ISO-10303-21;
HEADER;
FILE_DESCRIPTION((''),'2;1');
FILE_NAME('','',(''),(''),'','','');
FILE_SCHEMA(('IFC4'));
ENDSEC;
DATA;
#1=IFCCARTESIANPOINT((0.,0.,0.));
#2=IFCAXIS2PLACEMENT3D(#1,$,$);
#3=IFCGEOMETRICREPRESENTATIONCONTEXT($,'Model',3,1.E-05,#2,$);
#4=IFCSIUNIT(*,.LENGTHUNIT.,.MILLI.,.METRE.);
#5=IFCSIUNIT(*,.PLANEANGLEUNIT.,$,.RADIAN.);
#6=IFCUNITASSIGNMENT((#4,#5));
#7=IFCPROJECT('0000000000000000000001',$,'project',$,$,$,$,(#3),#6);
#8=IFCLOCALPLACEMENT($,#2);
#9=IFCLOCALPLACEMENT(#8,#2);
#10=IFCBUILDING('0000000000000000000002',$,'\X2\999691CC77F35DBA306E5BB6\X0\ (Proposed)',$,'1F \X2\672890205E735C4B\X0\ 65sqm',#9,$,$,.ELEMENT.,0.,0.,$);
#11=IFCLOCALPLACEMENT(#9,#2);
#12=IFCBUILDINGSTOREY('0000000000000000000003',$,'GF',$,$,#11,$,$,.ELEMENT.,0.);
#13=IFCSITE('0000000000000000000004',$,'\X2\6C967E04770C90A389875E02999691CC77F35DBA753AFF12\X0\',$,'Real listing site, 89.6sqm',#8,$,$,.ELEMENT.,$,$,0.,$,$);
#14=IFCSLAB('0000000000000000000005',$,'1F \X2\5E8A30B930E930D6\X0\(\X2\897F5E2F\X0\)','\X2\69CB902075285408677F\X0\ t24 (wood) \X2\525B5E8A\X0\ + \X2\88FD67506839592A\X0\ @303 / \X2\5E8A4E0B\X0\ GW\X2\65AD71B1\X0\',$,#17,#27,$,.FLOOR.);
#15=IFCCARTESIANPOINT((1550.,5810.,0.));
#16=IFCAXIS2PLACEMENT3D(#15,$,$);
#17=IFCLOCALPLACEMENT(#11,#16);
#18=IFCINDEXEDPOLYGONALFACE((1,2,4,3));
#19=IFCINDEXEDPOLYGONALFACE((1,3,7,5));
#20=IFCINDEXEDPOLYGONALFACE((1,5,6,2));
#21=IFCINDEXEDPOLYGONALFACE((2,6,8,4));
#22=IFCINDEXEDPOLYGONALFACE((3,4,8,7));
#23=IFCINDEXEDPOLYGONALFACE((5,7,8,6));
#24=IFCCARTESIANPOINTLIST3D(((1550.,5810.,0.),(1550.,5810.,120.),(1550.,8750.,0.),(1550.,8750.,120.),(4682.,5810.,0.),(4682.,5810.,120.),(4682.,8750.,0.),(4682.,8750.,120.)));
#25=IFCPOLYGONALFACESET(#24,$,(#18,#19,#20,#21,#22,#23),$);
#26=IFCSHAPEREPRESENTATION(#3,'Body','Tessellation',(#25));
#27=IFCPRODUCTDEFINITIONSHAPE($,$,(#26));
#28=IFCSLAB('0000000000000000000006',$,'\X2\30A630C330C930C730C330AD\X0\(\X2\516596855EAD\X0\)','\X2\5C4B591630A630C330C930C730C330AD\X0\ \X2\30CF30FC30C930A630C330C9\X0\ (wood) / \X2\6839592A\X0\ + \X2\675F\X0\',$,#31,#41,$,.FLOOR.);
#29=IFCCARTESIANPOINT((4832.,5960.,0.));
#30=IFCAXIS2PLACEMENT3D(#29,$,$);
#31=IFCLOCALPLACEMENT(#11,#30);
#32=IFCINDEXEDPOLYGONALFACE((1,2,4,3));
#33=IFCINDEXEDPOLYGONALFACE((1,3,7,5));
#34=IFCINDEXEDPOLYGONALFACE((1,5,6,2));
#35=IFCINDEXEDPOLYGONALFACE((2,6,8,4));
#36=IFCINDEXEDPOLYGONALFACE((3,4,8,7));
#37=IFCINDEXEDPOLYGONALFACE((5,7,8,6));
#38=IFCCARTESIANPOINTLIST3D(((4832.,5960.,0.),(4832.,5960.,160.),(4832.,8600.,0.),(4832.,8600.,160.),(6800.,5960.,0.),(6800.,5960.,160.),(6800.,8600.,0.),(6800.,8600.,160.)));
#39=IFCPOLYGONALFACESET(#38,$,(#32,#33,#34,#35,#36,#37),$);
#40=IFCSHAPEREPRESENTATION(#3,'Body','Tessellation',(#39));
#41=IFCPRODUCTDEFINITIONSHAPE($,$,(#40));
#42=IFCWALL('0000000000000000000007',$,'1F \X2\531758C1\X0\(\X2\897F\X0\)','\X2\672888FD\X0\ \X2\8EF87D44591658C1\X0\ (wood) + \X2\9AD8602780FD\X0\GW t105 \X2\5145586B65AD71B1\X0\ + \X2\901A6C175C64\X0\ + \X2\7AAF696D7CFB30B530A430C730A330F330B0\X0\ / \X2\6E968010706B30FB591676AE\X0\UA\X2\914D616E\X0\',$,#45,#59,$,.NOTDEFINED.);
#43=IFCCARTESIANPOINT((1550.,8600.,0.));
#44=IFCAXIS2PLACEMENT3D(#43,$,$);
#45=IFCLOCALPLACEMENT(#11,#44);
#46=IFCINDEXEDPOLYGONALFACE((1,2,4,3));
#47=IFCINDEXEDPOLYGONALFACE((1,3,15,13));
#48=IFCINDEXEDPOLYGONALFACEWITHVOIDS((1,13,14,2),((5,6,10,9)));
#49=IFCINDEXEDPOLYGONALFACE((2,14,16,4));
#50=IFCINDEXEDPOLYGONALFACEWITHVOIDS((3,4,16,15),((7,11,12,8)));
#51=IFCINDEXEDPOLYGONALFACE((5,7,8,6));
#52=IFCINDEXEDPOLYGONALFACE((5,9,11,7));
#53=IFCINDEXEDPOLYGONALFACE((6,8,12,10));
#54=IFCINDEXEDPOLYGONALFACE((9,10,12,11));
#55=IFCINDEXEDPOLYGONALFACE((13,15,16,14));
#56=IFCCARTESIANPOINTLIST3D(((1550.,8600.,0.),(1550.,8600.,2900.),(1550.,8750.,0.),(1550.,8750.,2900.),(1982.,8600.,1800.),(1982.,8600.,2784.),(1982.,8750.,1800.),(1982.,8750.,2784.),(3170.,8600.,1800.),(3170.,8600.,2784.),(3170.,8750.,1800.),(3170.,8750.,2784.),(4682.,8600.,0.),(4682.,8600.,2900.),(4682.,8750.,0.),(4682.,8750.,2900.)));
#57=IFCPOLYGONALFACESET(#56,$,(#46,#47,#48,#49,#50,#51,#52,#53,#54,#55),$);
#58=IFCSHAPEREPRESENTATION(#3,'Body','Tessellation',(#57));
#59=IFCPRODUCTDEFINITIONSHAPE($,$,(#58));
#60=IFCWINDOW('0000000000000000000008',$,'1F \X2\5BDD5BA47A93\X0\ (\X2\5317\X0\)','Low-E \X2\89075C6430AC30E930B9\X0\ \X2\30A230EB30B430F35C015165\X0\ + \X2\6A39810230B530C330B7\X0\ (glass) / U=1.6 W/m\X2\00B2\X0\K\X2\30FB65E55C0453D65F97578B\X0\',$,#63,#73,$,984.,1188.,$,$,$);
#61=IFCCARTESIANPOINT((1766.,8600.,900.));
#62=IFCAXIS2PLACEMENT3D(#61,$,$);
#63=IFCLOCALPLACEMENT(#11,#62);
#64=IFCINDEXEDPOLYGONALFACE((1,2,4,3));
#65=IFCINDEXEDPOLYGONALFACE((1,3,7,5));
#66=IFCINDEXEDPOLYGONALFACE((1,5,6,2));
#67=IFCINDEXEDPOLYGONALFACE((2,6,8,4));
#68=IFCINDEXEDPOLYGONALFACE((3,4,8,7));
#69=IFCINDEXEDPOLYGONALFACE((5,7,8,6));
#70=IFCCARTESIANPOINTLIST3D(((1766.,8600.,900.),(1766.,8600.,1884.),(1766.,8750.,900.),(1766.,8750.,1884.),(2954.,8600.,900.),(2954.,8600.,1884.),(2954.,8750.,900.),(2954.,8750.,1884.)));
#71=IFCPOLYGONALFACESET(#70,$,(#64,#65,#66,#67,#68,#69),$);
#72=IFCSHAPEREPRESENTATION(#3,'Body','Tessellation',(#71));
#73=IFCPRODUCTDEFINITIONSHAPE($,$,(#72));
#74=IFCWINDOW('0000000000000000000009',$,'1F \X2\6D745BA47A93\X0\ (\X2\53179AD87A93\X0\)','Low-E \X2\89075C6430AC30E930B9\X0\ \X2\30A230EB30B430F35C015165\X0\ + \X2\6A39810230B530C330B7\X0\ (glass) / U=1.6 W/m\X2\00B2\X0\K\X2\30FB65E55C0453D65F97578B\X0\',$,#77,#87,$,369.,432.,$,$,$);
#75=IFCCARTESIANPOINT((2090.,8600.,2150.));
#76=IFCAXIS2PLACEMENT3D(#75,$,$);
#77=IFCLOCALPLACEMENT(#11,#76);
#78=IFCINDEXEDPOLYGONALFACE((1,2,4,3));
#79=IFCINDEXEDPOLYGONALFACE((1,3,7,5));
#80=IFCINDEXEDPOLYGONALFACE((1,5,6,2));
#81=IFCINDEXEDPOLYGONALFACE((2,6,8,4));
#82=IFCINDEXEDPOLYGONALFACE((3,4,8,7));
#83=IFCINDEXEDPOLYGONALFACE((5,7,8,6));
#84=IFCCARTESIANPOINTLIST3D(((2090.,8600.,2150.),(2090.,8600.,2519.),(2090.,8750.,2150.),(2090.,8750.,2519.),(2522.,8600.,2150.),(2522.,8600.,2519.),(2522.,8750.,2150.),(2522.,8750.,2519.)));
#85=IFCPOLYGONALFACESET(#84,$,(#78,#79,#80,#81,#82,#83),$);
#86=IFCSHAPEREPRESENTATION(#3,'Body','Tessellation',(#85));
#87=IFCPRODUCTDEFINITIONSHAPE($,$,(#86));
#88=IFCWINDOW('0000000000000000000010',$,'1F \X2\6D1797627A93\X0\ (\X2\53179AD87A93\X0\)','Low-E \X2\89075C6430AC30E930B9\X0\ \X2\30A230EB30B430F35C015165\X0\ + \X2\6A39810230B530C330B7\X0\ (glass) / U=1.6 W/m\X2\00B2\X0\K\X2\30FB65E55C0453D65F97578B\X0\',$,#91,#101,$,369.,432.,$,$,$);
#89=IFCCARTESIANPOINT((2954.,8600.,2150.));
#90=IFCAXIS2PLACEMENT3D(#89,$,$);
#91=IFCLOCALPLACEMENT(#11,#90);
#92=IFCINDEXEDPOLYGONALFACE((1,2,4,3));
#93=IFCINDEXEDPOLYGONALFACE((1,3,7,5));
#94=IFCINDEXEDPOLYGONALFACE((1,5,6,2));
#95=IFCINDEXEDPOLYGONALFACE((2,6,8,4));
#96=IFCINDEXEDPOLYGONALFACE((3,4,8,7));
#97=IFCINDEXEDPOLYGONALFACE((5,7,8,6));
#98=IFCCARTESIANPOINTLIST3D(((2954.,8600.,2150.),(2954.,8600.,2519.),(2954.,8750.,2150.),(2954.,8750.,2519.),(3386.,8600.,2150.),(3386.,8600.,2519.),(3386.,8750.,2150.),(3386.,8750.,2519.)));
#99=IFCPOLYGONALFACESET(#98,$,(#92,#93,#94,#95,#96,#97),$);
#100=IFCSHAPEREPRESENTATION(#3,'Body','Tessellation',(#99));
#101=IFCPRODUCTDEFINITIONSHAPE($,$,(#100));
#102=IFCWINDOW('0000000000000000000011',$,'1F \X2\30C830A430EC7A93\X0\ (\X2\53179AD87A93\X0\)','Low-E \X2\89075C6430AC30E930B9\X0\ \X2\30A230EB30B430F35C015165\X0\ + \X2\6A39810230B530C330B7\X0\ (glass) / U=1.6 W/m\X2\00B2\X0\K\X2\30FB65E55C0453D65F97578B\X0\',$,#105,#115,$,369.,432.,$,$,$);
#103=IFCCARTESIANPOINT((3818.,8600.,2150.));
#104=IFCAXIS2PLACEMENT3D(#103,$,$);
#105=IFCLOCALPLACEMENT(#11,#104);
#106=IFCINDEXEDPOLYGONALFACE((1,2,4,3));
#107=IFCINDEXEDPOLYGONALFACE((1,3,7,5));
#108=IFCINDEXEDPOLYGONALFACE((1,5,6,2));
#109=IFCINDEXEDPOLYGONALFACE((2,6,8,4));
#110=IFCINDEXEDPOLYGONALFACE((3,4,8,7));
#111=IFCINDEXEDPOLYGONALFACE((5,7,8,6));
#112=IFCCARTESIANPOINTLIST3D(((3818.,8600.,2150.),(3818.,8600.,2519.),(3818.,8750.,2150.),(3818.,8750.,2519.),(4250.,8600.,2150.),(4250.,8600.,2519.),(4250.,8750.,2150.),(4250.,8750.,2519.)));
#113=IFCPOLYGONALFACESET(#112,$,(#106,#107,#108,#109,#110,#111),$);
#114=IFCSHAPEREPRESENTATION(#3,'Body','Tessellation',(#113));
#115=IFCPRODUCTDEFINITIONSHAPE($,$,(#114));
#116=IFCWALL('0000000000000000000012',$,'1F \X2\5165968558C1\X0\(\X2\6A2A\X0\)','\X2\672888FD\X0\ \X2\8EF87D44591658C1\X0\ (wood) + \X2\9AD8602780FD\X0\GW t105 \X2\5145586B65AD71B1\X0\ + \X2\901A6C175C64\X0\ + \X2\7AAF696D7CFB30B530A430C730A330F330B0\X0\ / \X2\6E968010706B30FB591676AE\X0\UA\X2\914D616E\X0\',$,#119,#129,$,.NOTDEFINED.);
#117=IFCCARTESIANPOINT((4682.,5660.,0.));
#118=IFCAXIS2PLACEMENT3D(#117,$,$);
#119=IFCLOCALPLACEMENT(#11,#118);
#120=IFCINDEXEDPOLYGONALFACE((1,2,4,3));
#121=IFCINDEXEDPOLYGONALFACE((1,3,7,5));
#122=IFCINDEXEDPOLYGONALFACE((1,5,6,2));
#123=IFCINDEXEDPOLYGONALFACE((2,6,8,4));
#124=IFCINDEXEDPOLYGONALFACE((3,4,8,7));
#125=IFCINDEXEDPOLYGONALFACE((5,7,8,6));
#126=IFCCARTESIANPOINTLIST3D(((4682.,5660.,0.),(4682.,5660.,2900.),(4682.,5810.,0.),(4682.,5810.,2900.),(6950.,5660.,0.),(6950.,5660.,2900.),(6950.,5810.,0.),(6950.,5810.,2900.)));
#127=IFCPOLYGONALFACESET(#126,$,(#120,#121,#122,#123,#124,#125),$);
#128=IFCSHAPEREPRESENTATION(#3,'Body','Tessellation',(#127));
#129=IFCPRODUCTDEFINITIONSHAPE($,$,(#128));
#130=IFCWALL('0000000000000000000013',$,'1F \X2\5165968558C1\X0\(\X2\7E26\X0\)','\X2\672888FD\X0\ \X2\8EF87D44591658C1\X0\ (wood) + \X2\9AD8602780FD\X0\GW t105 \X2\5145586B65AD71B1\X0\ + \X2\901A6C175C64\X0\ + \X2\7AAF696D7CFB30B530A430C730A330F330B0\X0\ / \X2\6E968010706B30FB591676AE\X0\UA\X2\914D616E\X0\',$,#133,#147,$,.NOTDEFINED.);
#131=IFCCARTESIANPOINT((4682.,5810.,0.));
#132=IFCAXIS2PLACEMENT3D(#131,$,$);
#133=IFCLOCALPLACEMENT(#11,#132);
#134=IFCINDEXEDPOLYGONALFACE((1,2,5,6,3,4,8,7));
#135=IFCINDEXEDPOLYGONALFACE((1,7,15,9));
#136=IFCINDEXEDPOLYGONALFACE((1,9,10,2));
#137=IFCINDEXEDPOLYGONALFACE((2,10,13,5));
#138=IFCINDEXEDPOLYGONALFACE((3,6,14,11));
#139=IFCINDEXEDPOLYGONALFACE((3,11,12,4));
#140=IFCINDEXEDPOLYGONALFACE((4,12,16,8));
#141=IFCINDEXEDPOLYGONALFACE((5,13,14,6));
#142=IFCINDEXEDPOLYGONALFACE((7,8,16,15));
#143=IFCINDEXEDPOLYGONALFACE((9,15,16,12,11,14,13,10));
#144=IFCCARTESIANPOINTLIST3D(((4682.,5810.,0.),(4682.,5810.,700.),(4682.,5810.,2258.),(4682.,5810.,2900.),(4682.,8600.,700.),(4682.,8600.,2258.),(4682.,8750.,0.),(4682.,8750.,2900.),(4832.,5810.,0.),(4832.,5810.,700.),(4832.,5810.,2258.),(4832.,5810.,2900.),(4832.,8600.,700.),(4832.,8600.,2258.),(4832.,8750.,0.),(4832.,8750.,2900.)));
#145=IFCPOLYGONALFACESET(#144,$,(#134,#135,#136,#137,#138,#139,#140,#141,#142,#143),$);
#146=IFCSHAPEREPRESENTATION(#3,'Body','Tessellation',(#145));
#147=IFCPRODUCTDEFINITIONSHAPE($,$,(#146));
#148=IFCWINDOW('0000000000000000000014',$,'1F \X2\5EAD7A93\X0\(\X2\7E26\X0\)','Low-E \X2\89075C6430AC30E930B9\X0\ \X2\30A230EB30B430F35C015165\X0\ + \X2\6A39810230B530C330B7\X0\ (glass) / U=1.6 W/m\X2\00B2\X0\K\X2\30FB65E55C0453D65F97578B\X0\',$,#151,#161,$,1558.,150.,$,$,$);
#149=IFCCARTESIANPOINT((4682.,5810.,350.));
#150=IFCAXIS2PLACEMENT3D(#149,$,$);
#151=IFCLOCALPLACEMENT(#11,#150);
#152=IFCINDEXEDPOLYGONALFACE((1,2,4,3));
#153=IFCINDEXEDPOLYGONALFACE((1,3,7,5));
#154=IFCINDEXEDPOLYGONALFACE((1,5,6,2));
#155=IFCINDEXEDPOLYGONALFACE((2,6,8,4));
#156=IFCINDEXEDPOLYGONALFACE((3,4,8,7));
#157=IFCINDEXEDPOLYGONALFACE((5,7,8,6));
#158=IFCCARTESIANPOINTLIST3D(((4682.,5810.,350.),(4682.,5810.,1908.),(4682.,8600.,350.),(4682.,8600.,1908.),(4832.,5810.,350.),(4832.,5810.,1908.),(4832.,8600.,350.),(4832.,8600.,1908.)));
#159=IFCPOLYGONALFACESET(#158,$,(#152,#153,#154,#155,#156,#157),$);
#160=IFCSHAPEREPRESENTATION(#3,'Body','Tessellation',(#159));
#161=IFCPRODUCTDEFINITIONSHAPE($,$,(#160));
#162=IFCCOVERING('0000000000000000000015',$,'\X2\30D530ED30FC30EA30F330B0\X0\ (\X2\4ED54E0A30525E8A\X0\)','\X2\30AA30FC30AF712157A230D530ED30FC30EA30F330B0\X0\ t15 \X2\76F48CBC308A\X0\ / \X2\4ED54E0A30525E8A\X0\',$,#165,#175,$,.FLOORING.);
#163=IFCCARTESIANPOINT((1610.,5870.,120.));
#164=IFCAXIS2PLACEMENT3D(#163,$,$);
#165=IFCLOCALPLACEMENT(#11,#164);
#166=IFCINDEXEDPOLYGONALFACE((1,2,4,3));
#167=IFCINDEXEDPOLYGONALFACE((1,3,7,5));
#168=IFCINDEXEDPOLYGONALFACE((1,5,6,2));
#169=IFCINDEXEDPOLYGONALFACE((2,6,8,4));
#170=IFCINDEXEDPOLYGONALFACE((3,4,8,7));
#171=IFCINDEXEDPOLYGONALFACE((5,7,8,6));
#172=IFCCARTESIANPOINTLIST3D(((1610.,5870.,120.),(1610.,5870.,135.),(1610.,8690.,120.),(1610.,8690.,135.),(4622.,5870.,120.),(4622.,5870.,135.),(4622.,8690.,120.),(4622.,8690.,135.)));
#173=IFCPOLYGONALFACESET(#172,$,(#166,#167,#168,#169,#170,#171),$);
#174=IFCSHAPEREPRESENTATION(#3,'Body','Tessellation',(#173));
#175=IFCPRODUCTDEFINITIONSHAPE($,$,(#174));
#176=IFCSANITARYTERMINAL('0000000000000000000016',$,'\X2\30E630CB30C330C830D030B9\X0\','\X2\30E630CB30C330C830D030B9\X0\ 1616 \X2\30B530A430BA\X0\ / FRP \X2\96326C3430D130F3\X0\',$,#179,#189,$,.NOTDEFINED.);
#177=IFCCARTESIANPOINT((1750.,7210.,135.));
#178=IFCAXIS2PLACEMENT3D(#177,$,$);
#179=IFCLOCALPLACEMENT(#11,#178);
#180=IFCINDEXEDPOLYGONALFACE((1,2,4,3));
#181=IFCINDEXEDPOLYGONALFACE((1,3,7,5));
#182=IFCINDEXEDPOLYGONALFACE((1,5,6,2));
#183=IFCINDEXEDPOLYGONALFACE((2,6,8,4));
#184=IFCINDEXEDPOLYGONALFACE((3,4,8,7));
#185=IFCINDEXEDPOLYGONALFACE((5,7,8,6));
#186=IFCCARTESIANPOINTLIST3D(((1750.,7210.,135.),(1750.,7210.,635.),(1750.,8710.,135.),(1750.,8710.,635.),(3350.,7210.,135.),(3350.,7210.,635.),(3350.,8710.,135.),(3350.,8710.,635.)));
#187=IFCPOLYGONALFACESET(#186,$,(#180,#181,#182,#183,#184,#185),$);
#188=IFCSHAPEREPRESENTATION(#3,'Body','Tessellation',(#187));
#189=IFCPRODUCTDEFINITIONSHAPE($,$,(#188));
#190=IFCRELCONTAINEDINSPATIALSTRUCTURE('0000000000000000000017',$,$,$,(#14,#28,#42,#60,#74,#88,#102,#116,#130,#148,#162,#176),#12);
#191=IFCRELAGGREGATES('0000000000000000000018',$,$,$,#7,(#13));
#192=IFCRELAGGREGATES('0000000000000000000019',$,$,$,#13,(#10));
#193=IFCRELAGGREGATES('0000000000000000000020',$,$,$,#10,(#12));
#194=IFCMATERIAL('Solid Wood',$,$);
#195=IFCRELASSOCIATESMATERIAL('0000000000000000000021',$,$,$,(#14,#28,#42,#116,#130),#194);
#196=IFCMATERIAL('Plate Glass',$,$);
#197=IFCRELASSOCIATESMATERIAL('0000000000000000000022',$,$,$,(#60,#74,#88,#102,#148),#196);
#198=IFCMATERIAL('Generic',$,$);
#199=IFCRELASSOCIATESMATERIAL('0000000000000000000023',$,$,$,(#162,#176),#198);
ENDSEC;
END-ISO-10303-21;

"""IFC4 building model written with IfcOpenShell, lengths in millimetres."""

from ifc_helpers import new_model, si_unit, frame, frame_2d, origin, place, context, project, spatial, rectangle, extrude, material, element, fill, save


model = new_model("IFC4")

# Units and contexts
model_context = context("Model", 3, precision=1e-05, world=origin())
ifc_project = project(units=[si_unit("LENGTHUNIT", "METRE", prefix="MILLI"), si_unit("PLANEANGLEUNIT", "RADIAN")], contexts=[model_context])

# Site, building, storey
site_placement = place(None, origin())
site = spatial("IfcSite", under=ifc_project, at=site_placement, Name="沖縄県那覇市首里石嶺町２", ObjectType="Real listing site, 89.6sqm", CompositionType="ELEMENT", RefElevation=0.0)
building_placement = place(site_placement, origin())
building = spatial("IfcBuilding", under=site, at=building_placement, Name="首里石嶺の家 (Proposed)", ObjectType="1F 木造平屋 65sqm", CompositionType="ELEMENT", ElevationOfRefHeight=0.0, ElevationOfTerrain=0.0)
storey_placement = place(building_placement, origin())
storey = spatial("IfcBuildingStorey", under=building, at=storey_placement, Name="GF", CompositionType="ELEMENT", Elevation=0.0)

# Slabs
ifc_material_1 = material(Name="Solid Wood")
slab_1_placement = place(storey_placement, frame((1550.0, 5810.0, 0.0)))
element("IfcSlab", 1, at=slab_1_placement, inside=storey, material=ifc_material_1, Name="1F 床スラブ(西帯)", Description="構造用合板 t24 (wood) 剛床 + 製材根太 @303 / 床下 GW断熱", PredefinedType="FLOOR", context=model_context, shape_type="SweptSolid", body=[
    extrude(rectangle(XDim=3132.0, YDim=2940.0, at=frame_2d((1566.0, 1470.0))), frame((1550.0, 5810.0, 0.0)), (0.0, 0.0, 1.0), 120.0),
])
slab_2_placement = place(storey_placement, frame((4832.0, 5960.0, 0.0)))
element("IfcSlab", 2, at=slab_2_placement, inside=storey, material=ifc_material_1, Name="ウッドデッキ(入隅庭)", Description="屋外ウッドデッキ ハードウッド (wood) / 根太 + 束", PredefinedType="FLOOR", context=model_context, shape_type="SweptSolid", body=[
    extrude(rectangle(XDim=1968.0, YDim=2640.0, at=frame_2d((984.0, 1320.0))), frame((4832.0, 5960.0, 0.0)), (0.0, 0.0, 1.0), 160.0),
])

# Wall, openings, windows
wall_1_placement = place(storey_placement, frame((1550.0, 8600.0, 0.0)))
wall_1 = element("IfcWall", 3, at=wall_1_placement, inside=storey, material=ifc_material_1, Name="1F 北壁(西)", Description="木製 軸組外壁 (wood) + 高性能GW t105 充填断熱 + 通気層 + 窯業系サイディング / 準耐火・外皮UA配慮", PredefinedType="NOTDEFINED", context=model_context, shape_type="SweptSolid", body=[
    extrude(rectangle(XDim=3132.0, YDim=150.0, at=frame_2d((1566.0, 75.0))), frame((1550.0, 8600.0, 0.0)), (0.0, 0.0, 1.0), 2900.0),
])
opening_1_placement = place(storey_placement, frame((1766.0, 8600.0, 900.0)))
opening_1 = element("IfcOpeningElement", 4, at=opening_1_placement, cuts=wall_1, PredefinedType="NOTDEFINED", context=model_context, shape_type="SweptSolid", body=[
    extrude(rectangle(XDim=1188.0, YDim=150.0, at=frame_2d((594.0, 75.0))), frame((1766.0, 8600.0, 900.0)), (0.0, 0.0, 1.0), 984.0),
])
opening_2_placement = place(storey_placement, frame((2090.0, 8600.0, 2150.0)))
opening_2 = element("IfcOpeningElement", 5, at=opening_2_placement, cuts=wall_1, PredefinedType="NOTDEFINED", context=model_context, shape_type="SweptSolid", body=[
    extrude(rectangle(XDim=432.0, YDim=150.0, at=frame_2d((216.0, 75.0))), frame((2090.0, 8600.0, 2150.0)), (0.0, 0.0, 1.0), 369.0),
])
opening_3_placement = place(storey_placement, frame((2954.0, 8600.0, 2150.0)))
opening_3 = element("IfcOpeningElement", 6, at=opening_3_placement, cuts=wall_1, PredefinedType="NOTDEFINED", context=model_context, shape_type="SweptSolid", body=[
    extrude(rectangle(XDim=432.0, YDim=150.0, at=frame_2d((216.0, 75.0))), frame((2954.0, 8600.0, 2150.0)), (0.0, 0.0, 1.0), 369.0),
])
opening_4_placement = place(storey_placement, frame((3818.0, 8600.0, 2150.0)))
opening_4 = element("IfcOpeningElement", 7, at=opening_4_placement, cuts=wall_1, PredefinedType="NOTDEFINED", context=model_context, shape_type="SweptSolid", body=[
    extrude(rectangle(XDim=432.0, YDim=150.0, at=frame_2d((216.0, 75.0))), frame((3818.0, 8600.0, 2150.0)), (0.0, 0.0, 1.0), 369.0),
])
ifc_material_2 = material(Name="Plate Glass")
window_1_placement = place(storey_placement, frame((1766.0, 8600.0, 900.0)))
window_1 = element("IfcWindow", 8, at=window_1_placement, inside=storey, material=ifc_material_2, Name="1F 寝室窓 (北)", Description="Low-E 複層ガラス アルゴン封入 + 樹脂サッシ (glass) / U=1.6 W/m²K・日射取得型", OverallHeight=984.0, OverallWidth=1188.0, context=model_context, shape_type="SweptSolid", body=[
    extrude(rectangle(XDim=1188.0, YDim=150.0, at=frame_2d((594.0, 75.0))), frame((1766.0, 8600.0, 900.0)), (0.0, 0.0, 1.0), 984.0),
])
fill(opening_1, window_1)
window_2_placement = place(storey_placement, frame((2090.0, 8600.0, 2150.0)))
window_2 = element("IfcWindow", 9, at=window_2_placement, inside=storey, material=ifc_material_2, Name="1F 浴室窓 (北高窓)", Description="Low-E 複層ガラス アルゴン封入 + 樹脂サッシ (glass) / U=1.6 W/m²K・日射取得型", OverallHeight=369.0, OverallWidth=432.0, context=model_context, shape_type="SweptSolid", body=[
    extrude(rectangle(XDim=432.0, YDim=150.0, at=frame_2d((216.0, 75.0))), frame((2090.0, 8600.0, 2150.0)), (0.0, 0.0, 1.0), 369.0),
])
fill(opening_2, window_2)
window_3_placement = place(storey_placement, frame((2954.0, 8600.0, 2150.0)))
window_3 = element("IfcWindow", 10, at=window_3_placement, inside=storey, material=ifc_material_2, Name="1F 洗面窓 (北高窓)", Description="Low-E 複層ガラス アルゴン封入 + 樹脂サッシ (glass) / U=1.6 W/m²K・日射取得型", OverallHeight=369.0, OverallWidth=432.0, context=model_context, shape_type="SweptSolid", body=[
    extrude(rectangle(XDim=432.0, YDim=150.0, at=frame_2d((216.0, 75.0))), frame((2954.0, 8600.0, 2150.0)), (0.0, 0.0, 1.0), 369.0),
])
fill(opening_3, window_3)
window_4_placement = place(storey_placement, frame((3818.0, 8600.0, 2150.0)))
window_4 = element("IfcWindow", 11, at=window_4_placement, inside=storey, material=ifc_material_2, Name="1F トイレ窓 (北高窓)", Description="Low-E 複層ガラス アルゴン封入 + 樹脂サッシ (glass) / U=1.6 W/m²K・日射取得型", OverallHeight=369.0, OverallWidth=432.0, context=model_context, shape_type="SweptSolid", body=[
    extrude(rectangle(XDim=432.0, YDim=150.0, at=frame_2d((216.0, 75.0))), frame((3818.0, 8600.0, 2150.0)), (0.0, 0.0, 1.0), 369.0),
])
fill(opening_4, window_4)

# Wall
wall_2_placement = place(storey_placement, frame((4682.0, 5660.0, 0.0)))
element("IfcWall", 12, at=wall_2_placement, inside=storey, material=ifc_material_1, Name="1F 入隅壁(横)", Description="木製 軸組外壁 (wood) + 高性能GW t105 充填断熱 + 通気層 + 窯業系サイディング / 準耐火・外皮UA配慮", PredefinedType="NOTDEFINED", context=model_context, shape_type="SweptSolid", body=[
    extrude(rectangle(XDim=2268.0, YDim=150.0, at=frame_2d((1134.0, 75.0))), frame((4682.0, 5660.0, 0.0)), (0.0, 0.0, 1.0), 2900.0),
])

# Wall, opening, window
wall_3_placement = place(storey_placement, frame((4682.0, 5810.0, 0.0)))
wall_3 = element("IfcWall", 13, at=wall_3_placement, inside=storey, material=ifc_material_1, Name="1F 入隅壁(縦)", Description="木製 軸組外壁 (wood) + 高性能GW t105 充填断熱 + 通気層 + 窯業系サイディング / 準耐火・外皮UA配慮", PredefinedType="NOTDEFINED", context=model_context, shape_type="SweptSolid", body=[
    extrude(rectangle(XDim=150.0, YDim=2940.0, at=frame_2d((75.0, 1470.0))), frame((4682.0, 5810.0, 0.0)), (0.0, 0.0, 1.0), 2900.0),
])
opening_5_placement = place(storey_placement, frame((4682.0, 5810.0, 350.0)))
opening_5 = element("IfcOpeningElement", 14, at=opening_5_placement, cuts=wall_3, PredefinedType="NOTDEFINED", context=model_context, shape_type="SweptSolid", body=[
    extrude(rectangle(XDim=150.0, YDim=2790.0, at=frame_2d((75.0, 1395.0))), frame((4682.0, 5810.0, 350.0)), (0.0, 0.0, 1.0), 1558.0),
])
window_5_placement = place(storey_placement, frame((4682.0, 5810.0, 350.0)))
window_5 = element("IfcWindow", 15, at=window_5_placement, inside=storey, material=ifc_material_2, Name="1F 庭窓(縦)", Description="Low-E 複層ガラス アルゴン封入 + 樹脂サッシ (glass) / U=1.6 W/m²K・日射取得型", OverallHeight=1558.0, OverallWidth=150.0, context=model_context, shape_type="SweptSolid", body=[
    extrude(rectangle(XDim=150.0, YDim=2790.0, at=frame_2d((75.0, 1395.0))), frame((4682.0, 5810.0, 350.0)), (0.0, 0.0, 1.0), 1558.0),
])
fill(opening_5, window_5)

# Covering
ifc_material_3 = material(Name="Generic")
covering_placement = place(storey_placement, frame((1610.0, 5870.0, 120.0)))
element("IfcCovering", 16, at=covering_placement, inside=storey, material=ifc_material_3, Name="フローリング (仕上げ床)", Description="オーク無垢フローリング t15 直貼り / 仕上げ床", PredefinedType="FLOORING", context=model_context, shape_type="SweptSolid", body=[
    extrude(rectangle(XDim=3012.0, YDim=2820.0, at=frame_2d((1506.0, 1410.0))), frame((1610.0, 5870.0, 120.0)), (0.0, 0.0, 1.0), 15.0),
])

# Sanitary terminal
sanitary_terminal_1_placement = place(storey_placement, frame((1750.0, 7210.0, 135.0)))
element("IfcSanitaryTerminal", 17, at=sanitary_terminal_1_placement, inside=storey, material=ifc_material_3, Name="ユニットバス", Description="ユニットバス 1616 サイズ / FRP 防水パン", PredefinedType="NOTDEFINED", context=model_context, shape_type="SweptSolid", body=[
    extrude(rectangle(XDim=1600.0, YDim=1500.0, at=frame_2d((800.0, 750.0))), frame((1750.0, 7210.0, 135.0)), (0.0, 0.0, 1.0), 500.0),
])

save(model, "model.ifc")
